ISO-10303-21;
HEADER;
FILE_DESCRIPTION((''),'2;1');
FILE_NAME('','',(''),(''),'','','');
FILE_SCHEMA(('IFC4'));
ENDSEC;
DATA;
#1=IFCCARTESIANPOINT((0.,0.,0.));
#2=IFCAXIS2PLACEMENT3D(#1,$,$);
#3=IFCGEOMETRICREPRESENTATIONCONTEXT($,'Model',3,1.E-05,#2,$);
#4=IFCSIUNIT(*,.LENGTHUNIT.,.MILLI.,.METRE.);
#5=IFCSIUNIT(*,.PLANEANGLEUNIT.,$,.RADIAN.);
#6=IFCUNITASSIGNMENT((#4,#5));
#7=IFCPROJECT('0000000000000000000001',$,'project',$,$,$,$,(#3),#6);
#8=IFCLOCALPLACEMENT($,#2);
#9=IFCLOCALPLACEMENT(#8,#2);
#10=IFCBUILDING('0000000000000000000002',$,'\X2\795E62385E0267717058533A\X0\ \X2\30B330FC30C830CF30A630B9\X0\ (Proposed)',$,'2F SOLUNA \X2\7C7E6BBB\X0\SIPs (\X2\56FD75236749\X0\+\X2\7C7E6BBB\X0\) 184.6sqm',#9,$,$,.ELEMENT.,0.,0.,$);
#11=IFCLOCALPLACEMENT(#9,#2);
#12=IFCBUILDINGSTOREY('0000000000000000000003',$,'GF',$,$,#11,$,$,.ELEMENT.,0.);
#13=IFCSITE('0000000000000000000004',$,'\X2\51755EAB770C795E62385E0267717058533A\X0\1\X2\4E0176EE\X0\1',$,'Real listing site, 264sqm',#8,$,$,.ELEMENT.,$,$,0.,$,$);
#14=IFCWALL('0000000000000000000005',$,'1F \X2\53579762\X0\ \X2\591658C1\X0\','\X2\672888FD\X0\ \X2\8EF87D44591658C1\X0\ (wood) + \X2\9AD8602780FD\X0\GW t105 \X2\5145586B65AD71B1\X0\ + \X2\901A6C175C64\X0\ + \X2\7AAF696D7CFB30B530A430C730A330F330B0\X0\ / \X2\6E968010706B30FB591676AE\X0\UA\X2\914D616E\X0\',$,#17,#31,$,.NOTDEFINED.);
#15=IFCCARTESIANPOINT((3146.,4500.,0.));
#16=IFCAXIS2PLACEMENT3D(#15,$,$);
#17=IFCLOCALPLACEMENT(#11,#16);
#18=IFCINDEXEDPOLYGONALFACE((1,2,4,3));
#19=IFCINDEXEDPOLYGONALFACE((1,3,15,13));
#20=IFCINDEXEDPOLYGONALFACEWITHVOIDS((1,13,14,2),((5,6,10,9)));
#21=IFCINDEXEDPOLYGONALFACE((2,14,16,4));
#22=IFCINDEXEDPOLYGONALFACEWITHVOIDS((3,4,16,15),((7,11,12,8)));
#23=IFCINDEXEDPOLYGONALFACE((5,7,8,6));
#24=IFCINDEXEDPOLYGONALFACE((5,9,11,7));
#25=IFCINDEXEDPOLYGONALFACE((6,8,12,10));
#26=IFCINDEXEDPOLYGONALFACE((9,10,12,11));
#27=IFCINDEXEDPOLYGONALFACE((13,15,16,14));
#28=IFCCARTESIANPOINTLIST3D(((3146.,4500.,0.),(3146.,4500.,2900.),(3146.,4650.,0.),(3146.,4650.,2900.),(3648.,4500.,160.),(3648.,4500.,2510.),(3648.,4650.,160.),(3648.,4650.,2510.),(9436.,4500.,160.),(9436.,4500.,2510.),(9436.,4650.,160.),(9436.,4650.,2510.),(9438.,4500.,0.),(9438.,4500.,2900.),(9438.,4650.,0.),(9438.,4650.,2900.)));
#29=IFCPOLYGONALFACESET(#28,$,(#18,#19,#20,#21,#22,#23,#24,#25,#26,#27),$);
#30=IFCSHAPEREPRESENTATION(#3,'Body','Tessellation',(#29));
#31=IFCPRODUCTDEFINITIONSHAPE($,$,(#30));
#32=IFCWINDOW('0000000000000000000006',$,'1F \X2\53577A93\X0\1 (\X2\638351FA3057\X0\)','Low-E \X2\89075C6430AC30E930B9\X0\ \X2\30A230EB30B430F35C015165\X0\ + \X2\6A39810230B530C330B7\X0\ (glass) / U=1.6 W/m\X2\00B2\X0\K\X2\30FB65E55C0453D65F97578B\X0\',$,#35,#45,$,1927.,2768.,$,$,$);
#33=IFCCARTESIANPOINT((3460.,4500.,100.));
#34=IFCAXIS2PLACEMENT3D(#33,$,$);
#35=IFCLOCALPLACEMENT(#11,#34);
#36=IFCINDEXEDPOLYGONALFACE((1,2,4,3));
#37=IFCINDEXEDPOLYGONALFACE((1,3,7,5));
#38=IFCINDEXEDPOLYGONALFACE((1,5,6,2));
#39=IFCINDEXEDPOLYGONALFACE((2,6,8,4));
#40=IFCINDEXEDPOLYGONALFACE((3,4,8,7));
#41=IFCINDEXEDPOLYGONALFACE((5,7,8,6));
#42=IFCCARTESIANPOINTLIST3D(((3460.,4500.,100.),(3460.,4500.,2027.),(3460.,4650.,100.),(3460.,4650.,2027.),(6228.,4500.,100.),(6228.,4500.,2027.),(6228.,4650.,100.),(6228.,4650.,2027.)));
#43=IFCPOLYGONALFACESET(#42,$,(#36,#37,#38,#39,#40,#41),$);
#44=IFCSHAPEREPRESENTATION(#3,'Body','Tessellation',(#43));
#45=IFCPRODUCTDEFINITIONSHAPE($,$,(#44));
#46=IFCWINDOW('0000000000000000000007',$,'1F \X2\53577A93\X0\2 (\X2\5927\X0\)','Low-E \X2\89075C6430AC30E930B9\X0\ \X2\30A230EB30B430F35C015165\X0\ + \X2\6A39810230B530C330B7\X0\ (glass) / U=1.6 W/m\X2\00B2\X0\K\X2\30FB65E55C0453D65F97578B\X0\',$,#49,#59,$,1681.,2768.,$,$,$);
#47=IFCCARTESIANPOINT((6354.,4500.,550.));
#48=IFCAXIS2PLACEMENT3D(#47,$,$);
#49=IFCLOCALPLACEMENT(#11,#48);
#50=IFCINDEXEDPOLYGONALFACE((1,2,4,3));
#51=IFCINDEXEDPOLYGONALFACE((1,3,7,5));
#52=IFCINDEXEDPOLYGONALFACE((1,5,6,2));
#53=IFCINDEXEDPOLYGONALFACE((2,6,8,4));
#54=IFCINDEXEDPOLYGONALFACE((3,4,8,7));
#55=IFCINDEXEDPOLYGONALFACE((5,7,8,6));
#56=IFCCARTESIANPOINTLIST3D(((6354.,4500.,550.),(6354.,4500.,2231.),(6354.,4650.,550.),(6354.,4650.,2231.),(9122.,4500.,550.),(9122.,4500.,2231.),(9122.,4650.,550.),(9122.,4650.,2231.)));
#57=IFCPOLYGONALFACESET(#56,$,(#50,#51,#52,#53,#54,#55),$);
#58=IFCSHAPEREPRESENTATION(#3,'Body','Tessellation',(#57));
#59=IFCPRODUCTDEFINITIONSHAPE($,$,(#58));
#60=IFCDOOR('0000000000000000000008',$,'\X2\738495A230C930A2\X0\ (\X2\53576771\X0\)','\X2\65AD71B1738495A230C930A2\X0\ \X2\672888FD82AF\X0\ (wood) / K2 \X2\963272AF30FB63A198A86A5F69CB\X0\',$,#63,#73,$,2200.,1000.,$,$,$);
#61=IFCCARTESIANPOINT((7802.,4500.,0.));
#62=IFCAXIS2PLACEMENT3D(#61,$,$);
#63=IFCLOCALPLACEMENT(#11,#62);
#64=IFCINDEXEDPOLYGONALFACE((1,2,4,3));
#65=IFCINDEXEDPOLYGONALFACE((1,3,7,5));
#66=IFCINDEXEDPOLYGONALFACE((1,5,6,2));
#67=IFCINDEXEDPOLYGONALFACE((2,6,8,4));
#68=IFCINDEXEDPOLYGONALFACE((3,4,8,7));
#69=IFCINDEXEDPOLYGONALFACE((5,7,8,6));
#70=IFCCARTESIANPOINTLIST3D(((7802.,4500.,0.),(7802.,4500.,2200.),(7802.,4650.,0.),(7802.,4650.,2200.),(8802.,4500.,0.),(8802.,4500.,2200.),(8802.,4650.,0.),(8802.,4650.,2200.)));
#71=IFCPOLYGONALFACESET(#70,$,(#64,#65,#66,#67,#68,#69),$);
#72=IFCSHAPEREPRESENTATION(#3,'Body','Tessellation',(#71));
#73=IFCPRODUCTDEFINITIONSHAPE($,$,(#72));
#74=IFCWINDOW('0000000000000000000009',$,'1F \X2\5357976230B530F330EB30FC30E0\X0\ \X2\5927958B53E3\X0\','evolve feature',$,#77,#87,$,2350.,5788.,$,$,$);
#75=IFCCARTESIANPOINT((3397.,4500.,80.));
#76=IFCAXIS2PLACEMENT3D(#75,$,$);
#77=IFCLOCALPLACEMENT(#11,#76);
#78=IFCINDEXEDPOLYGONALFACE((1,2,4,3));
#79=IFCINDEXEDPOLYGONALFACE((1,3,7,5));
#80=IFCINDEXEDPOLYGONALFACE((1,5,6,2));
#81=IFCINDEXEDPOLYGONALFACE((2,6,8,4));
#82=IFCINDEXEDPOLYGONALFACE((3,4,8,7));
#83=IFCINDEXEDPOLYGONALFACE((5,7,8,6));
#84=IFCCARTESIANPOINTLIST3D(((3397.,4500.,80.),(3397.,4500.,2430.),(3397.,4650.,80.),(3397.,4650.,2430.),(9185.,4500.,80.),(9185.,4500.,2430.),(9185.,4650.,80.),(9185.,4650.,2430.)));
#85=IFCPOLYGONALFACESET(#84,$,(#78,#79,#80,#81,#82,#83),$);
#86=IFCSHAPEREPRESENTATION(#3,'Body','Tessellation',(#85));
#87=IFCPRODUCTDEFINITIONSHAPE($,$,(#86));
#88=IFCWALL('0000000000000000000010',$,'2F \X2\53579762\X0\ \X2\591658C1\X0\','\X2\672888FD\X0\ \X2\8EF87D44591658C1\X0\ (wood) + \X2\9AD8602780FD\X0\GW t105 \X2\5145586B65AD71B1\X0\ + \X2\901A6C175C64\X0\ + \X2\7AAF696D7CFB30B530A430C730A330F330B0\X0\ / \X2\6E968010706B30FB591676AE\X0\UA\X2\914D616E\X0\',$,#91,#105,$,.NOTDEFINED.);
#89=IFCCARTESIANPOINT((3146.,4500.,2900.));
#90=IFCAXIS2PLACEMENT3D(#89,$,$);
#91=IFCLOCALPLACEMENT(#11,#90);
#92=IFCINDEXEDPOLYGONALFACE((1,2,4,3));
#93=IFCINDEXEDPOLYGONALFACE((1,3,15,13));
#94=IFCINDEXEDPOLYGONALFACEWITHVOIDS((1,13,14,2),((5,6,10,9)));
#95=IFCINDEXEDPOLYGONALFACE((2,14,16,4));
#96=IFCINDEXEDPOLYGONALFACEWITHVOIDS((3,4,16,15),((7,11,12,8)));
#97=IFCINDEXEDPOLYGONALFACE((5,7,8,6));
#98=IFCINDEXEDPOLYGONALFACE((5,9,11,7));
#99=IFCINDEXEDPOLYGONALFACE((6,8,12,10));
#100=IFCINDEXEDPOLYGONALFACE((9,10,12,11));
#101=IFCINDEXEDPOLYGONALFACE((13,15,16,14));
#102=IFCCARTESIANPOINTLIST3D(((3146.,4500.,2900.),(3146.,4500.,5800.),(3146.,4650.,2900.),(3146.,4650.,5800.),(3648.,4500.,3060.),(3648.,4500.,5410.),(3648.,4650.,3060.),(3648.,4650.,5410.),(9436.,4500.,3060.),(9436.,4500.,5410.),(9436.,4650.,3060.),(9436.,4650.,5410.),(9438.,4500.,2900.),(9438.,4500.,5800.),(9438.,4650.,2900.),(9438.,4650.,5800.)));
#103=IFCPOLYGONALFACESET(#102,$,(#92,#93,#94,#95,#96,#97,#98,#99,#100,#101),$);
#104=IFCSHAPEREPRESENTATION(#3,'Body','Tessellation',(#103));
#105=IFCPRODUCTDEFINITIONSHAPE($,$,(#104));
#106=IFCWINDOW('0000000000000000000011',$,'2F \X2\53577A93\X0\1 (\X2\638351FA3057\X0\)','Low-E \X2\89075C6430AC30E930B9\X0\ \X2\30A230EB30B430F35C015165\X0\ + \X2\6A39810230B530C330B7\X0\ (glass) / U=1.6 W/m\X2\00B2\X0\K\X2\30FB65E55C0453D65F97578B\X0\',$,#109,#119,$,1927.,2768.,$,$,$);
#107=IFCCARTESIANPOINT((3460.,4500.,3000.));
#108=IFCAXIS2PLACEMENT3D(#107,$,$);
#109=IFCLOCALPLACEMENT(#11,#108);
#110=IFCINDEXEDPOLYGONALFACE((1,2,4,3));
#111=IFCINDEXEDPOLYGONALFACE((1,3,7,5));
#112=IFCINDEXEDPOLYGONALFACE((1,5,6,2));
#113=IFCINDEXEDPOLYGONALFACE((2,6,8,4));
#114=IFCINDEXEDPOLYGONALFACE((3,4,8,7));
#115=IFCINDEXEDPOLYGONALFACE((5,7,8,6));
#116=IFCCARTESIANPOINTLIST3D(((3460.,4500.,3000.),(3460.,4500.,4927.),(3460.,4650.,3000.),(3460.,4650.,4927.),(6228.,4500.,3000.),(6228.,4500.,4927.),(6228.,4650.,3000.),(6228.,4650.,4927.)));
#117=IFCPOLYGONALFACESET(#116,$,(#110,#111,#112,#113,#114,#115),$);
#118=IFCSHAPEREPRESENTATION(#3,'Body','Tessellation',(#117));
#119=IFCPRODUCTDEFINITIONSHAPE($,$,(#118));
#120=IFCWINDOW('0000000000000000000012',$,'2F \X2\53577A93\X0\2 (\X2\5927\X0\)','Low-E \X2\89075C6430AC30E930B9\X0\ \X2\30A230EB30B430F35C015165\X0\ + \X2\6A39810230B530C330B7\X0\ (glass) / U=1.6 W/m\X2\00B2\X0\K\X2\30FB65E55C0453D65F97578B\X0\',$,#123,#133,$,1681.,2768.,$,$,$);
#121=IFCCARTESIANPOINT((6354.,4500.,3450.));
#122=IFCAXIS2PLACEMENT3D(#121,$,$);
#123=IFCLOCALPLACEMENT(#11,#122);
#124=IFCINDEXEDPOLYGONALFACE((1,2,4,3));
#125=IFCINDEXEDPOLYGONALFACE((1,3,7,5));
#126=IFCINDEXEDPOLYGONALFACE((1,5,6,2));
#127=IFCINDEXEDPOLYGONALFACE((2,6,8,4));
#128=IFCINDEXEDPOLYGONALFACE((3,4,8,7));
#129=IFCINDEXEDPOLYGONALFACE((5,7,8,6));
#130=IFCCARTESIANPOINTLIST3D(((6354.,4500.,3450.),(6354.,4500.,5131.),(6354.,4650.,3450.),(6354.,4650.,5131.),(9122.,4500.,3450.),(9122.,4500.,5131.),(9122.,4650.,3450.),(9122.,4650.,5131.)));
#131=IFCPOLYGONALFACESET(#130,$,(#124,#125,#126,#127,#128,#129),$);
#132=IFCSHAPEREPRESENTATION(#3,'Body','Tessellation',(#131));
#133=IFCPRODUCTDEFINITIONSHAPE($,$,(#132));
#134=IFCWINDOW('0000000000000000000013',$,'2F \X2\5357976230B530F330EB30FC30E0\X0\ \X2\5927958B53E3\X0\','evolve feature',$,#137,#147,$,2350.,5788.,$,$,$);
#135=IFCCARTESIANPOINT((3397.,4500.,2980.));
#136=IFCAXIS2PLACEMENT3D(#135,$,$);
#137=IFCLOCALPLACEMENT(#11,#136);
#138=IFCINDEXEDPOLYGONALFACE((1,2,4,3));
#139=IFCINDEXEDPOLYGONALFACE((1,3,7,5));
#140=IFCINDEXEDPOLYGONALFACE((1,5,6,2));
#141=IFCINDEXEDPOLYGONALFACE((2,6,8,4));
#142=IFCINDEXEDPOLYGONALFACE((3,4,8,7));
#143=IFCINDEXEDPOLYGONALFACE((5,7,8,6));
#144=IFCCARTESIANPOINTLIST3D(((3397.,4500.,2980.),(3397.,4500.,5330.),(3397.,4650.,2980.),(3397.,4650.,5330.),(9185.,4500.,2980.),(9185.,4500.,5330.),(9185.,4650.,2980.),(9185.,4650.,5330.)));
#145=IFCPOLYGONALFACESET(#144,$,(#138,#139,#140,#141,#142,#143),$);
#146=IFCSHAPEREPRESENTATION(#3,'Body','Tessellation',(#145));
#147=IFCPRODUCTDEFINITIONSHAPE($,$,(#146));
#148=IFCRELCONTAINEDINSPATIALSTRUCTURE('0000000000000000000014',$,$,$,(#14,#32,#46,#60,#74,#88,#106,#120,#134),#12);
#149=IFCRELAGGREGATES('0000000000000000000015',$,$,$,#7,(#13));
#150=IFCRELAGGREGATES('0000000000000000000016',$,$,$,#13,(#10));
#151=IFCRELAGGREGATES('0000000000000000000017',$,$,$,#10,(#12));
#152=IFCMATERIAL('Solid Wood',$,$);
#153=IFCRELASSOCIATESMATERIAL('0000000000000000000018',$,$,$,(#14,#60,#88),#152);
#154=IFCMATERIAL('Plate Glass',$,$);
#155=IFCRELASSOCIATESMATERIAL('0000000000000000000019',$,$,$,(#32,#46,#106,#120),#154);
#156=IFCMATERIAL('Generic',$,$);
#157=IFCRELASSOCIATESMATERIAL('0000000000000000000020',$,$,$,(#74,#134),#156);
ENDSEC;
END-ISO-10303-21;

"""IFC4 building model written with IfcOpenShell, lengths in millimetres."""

from ifc_helpers import new_model, si_unit, frame, frame_2d, origin, place, context, project, spatial, rectangle, extrude, material, element, fill, save


model = new_model("IFC4")

# Units and contexts
model_context = context("Model", 3, precision=1e-05, world=origin())
ifc_project = project(units=[si_unit("LENGTHUNIT", "METRE", prefix="MILLI"), si_unit("PLANEANGLEUNIT", "RADIAN")], contexts=[model_context])

# Site, building, storey
site_placement = place(None, origin())
site = spatial("IfcSite", under=ifc_project, at=site_placement, Name="兵庫県神戸市東灘区1丁目1", ObjectType="Real listing site, 264sqm", CompositionType="ELEMENT", RefElevation=0.0)
building_placement = place(site_placement, origin())
building = spatial("IfcBuilding", under=site, at=building_placement, Name="神戸市東灘区 コートハウス (Proposed)", ObjectType="2F SOLUNA 籾殻SIPs (国産杉+籾殻) 184.6sqm", CompositionType="ELEMENT", ElevationOfRefHeight=0.0, ElevationOfTerrain=0.0)
storey_placement = place(building_placement, origin())
storey = spatial("IfcBuildingStorey", under=building, at=storey_placement, Name="GF", CompositionType="ELEMENT", Elevation=0.0)

# Shared definitions
ifc_material_1 = material(Name="Solid Wood")
ifc_material_2 = material(Name="Generic")

# Wall, openings, windows, door
wall_1_placement = place(storey_placement, frame((3146.0, 4500.0, 0.0)))
wall_1 = element("IfcWall", 1, at=wall_1_placement, inside=storey, material=ifc_material_1, Name="1F 南面 外壁", Description="木製 軸組外壁 (wood) + 高性能GW t105 充填断熱 + 通気層 + 窯業系サイディング / 準耐火・外皮UA配慮", PredefinedType="NOTDEFINED", context=model_context, shape_type="SweptSolid", body=[
    extrude(rectangle(XDim=6292.0, YDim=150.0, at=frame_2d((3146.0, 75.0))), frame((3146.0, 4500.0, 0.0)), (0.0, 0.0, 1.0), 2900.0),
])
opening_1_placement = place(storey_placement, frame((3460.0, 4500.0, 100.0)))
opening_1 = element("IfcOpeningElement", 2, at=opening_1_placement, cuts=wall_1, PredefinedType="NOTDEFINED", context=model_context, shape_type="SweptSolid", body=[
    extrude(rectangle(XDim=2768.0, YDim=150.0, at=frame_2d((1384.0, 75.0))), frame((3460.0, 4500.0, 100.0)), (0.0, 0.0, 1.0), 1927.0),
])
opening_2_placement = place(storey_placement, frame((6354.0, 4500.0, 550.0)))
opening_2 = element("IfcOpeningElement", 3, at=opening_2_placement, cuts=wall_1, PredefinedType="NOTDEFINED", context=model_context, shape_type="SweptSolid", body=[
    extrude(rectangle(XDim=2768.0, YDim=150.0, at=frame_2d((1384.0, 75.0))), frame((6354.0, 4500.0, 550.0)), (0.0, 0.0, 1.0), 1681.0),
])
opening_3_placement = place(storey_placement, frame((7802.0, 4500.0, 0.0)))
opening_3 = element("IfcOpeningElement", 4, at=opening_3_placement, cuts=wall_1, PredefinedType="NOTDEFINED", context=model_context, shape_type="SweptSolid", body=[
    extrude(rectangle(XDim=1000.0, YDim=150.0, at=frame_2d((500.0, 75.0))), frame((7802.0, 4500.0, 0.0)), (0.0, 0.0, 1.0), 2200.0),
])
opening_4_placement = place(storey_placement, frame((3397.0, 4500.0, 80.0)))
opening_4 = element("IfcOpeningElement", 5, at=opening_4_placement, cuts=wall_1, PredefinedType="NOTDEFINED", context=model_context, shape_type="SweptSolid", body=[
    extrude(rectangle(XDim=5788.0, YDim=150.0, at=frame_2d((2894.0, 75.0))), frame((3397.0, 4500.0, 80.0)), (0.0, 0.0, 1.0), 2350.0),
])
ifc_material_3 = material(Name="Plate Glass")
window_1_placement = place(storey_placement, frame((3460.0, 4500.0, 100.0)))
window_1 = element("IfcWindow", 6, at=window_1_placement, inside=storey, material=ifc_material_3, Name="1F 南窓1 (掃出し)", Description="Low-E 複層ガラス アルゴン封入 + 樹脂サッシ (glass) / U=1.6 W/m²K・日射取得型", OverallHeight=1927.0, OverallWidth=2768.0, context=model_context, shape_type="SweptSolid", body=[
    extrude(rectangle(XDim=2768.0, YDim=150.0, at=frame_2d((1384.0, 75.0))), frame((3460.0, 4500.0, 100.0)), (0.0, 0.0, 1.0), 1927.0),
])
fill(opening_1, window_1)
window_2_placement = place(storey_placement, frame((6354.0, 4500.0, 550.0)))
window_2 = element("IfcWindow", 7, at=window_2_placement, inside=storey, material=ifc_material_3, Name="1F 南窓2 (大)", Description="Low-E 複層ガラス アルゴン封入 + 樹脂サッシ (glass) / U=1.6 W/m²K・日射取得型", OverallHeight=1681.0, OverallWidth=2768.0, context=model_context, shape_type="SweptSolid", body=[
    extrude(rectangle(XDim=2768.0, YDim=150.0, at=frame_2d((1384.0, 75.0))), frame((6354.0, 4500.0, 550.0)), (0.0, 0.0, 1.0), 1681.0),
])
fill(opening_2, window_2)
door_placement = place(storey_placement, frame((7802.0, 4500.0, 0.0)))
door = element("IfcDoor", 8, at=door_placement, inside=storey, material=ifc_material_1, Name="玄関ドア (南東)", Description="断熱玄関ドア 木製芯 (wood) / K2 防犯・採風機構", OverallHeight=2200.0, OverallWidth=1000.0, context=model_context, shape_type="SweptSolid", body=[
    extrude(rectangle(XDim=1000.0, YDim=150.0, at=frame_2d((500.0, 75.0))), frame((7802.0, 4500.0, 0.0)), (0.0, 0.0, 1.0), 2200.0),
])
fill(opening_3, door)
window_3_placement = place(storey_placement, frame((3397.0, 4500.0, 80.0)))
window_3 = element("IfcWindow", 9, at=window_3_placement, inside=storey, material=ifc_material_2, Name="1F 南面サンルーム 大開口", Description="evolve feature", OverallHeight=2350.0, OverallWidth=5788.0, context=model_context, shape_type="SweptSolid", body=[
    extrude(rectangle(XDim=5788.0, YDim=150.0, at=frame_2d((2894.0, 75.0))), frame((3397.0, 4500.0, 80.0)), (0.0, 0.0, 1.0), 2350.0),
])
fill(opening_4, window_3)

# Wall, openings, windows
wall_2_placement = place(storey_placement, frame((3146.0, 4500.0, 2900.0)))
wall_2 = element("IfcWall", 10, at=wall_2_placement, inside=storey, material=ifc_material_1, Name="2F 南面 外壁", Description="木製 軸組外壁 (wood) + 高性能GW t105 充填断熱 + 通気層 + 窯業系サイディング / 準耐火・外皮UA配慮", PredefinedType="NOTDEFINED", context=model_context, shape_type="SweptSolid", body=[
    extrude(rectangle(XDim=6292.0, YDim=150.0, at=frame_2d((3146.0, 75.0))), frame((3146.0, 4500.0, 2900.0)), (0.0, 0.0, 1.0), 2900.0),
])
opening_5_placement = place(storey_placement, frame((3460.0, 4500.0, 3000.0)))
opening_5 = element("IfcOpeningElement", 11, at=opening_5_placement, cuts=wall_2, PredefinedType="NOTDEFINED", context=model_context, shape_type="SweptSolid", body=[
    extrude(rectangle(XDim=2768.0, YDim=150.0, at=frame_2d((1384.0, 75.0))), frame((3460.0, 4500.0, 3000.0)), (0.0, 0.0, 1.0), 1927.0),
])
opening_6_placement = place(storey_placement, frame((6354.0, 4500.0, 3450.0)))
opening_6 = element("IfcOpeningElement", 12, at=opening_6_placement, cuts=wall_2, PredefinedType="NOTDEFINED", context=model_context, shape_type="SweptSolid", body=[
    extrude(rectangle(XDim=2768.0, YDim=150.0, at=frame_2d((1384.0, 75.0))), frame((6354.0, 4500.0, 3450.0)), (0.0, 0.0, 1.0), 1681.0),
])
opening_7_placement = place(storey_placement, frame((3397.0, 4500.0, 2980.0)))
opening_7 = element("IfcOpeningElement", 13, at=opening_7_placement, cuts=wall_2, PredefinedType="NOTDEFINED", context=model_context, shape_type="SweptSolid", body=[
    extrude(rectangle(XDim=5788.0, YDim=150.0, at=frame_2d((2894.0, 75.0))), frame((3397.0, 4500.0, 2980.0)), (0.0, 0.0, 1.0), 2350.0),
])
window_4_placement = place(storey_placement, frame((3460.0, 4500.0, 3000.0)))
window_4 = element("IfcWindow", 14, at=window_4_placement, inside=storey, material=ifc_material_3, Name="2F 南窓1 (掃出し)", Description="Low-E 複層ガラス アルゴン封入 + 樹脂サッシ (glass) / U=1.6 W/m²K・日射取得型", OverallHeight=1927.0, OverallWidth=2768.0, context=model_context, shape_type="SweptSolid", body=[
    extrude(rectangle(XDim=2768.0, YDim=150.0, at=frame_2d((1384.0, 75.0))), frame((3460.0, 4500.0, 3000.0)), (0.0, 0.0, 1.0), 1927.0),
])
fill(opening_5, window_4)
window_5_placement = place(storey_placement, frame((6354.0, 4500.0, 3450.0)))
window_5 = element("IfcWindow", 15, at=window_5_placement, inside=storey, material=ifc_material_3, Name="2F 南窓2 (大)", Description="Low-E 複層ガラス アルゴン封入 + 樹脂サッシ (glass) / U=1.6 W/m²K・日射取得型", OverallHeight=1681.0, OverallWidth=2768.0, context=model_context, shape_type="SweptSolid", body=[
    extrude(rectangle(XDim=2768.0, YDim=150.0, at=frame_2d((1384.0, 75.0))), frame((6354.0, 4500.0, 3450.0)), (0.0, 0.0, 1.0), 1681.0),
])
fill(opening_6, window_5)
window_6_placement = place(storey_placement, frame((3397.0, 4500.0, 2980.0)))
window_6 = element("IfcWindow", 16, at=window_6_placement, inside=storey, material=ifc_material_2, Name="2F 南面サンルーム 大開口", Description="evolve feature", OverallHeight=2350.0, OverallWidth=5788.0, context=model_context, shape_type="SweptSolid", body=[
    extrude(rectangle(XDim=5788.0, YDim=150.0, at=frame_2d((2894.0, 75.0))), frame((3397.0, 4500.0, 2980.0)), (0.0, 0.0, 1.0), 2350.0),
])
fill(opening_7, window_6)

save(model, "model.ifc")
